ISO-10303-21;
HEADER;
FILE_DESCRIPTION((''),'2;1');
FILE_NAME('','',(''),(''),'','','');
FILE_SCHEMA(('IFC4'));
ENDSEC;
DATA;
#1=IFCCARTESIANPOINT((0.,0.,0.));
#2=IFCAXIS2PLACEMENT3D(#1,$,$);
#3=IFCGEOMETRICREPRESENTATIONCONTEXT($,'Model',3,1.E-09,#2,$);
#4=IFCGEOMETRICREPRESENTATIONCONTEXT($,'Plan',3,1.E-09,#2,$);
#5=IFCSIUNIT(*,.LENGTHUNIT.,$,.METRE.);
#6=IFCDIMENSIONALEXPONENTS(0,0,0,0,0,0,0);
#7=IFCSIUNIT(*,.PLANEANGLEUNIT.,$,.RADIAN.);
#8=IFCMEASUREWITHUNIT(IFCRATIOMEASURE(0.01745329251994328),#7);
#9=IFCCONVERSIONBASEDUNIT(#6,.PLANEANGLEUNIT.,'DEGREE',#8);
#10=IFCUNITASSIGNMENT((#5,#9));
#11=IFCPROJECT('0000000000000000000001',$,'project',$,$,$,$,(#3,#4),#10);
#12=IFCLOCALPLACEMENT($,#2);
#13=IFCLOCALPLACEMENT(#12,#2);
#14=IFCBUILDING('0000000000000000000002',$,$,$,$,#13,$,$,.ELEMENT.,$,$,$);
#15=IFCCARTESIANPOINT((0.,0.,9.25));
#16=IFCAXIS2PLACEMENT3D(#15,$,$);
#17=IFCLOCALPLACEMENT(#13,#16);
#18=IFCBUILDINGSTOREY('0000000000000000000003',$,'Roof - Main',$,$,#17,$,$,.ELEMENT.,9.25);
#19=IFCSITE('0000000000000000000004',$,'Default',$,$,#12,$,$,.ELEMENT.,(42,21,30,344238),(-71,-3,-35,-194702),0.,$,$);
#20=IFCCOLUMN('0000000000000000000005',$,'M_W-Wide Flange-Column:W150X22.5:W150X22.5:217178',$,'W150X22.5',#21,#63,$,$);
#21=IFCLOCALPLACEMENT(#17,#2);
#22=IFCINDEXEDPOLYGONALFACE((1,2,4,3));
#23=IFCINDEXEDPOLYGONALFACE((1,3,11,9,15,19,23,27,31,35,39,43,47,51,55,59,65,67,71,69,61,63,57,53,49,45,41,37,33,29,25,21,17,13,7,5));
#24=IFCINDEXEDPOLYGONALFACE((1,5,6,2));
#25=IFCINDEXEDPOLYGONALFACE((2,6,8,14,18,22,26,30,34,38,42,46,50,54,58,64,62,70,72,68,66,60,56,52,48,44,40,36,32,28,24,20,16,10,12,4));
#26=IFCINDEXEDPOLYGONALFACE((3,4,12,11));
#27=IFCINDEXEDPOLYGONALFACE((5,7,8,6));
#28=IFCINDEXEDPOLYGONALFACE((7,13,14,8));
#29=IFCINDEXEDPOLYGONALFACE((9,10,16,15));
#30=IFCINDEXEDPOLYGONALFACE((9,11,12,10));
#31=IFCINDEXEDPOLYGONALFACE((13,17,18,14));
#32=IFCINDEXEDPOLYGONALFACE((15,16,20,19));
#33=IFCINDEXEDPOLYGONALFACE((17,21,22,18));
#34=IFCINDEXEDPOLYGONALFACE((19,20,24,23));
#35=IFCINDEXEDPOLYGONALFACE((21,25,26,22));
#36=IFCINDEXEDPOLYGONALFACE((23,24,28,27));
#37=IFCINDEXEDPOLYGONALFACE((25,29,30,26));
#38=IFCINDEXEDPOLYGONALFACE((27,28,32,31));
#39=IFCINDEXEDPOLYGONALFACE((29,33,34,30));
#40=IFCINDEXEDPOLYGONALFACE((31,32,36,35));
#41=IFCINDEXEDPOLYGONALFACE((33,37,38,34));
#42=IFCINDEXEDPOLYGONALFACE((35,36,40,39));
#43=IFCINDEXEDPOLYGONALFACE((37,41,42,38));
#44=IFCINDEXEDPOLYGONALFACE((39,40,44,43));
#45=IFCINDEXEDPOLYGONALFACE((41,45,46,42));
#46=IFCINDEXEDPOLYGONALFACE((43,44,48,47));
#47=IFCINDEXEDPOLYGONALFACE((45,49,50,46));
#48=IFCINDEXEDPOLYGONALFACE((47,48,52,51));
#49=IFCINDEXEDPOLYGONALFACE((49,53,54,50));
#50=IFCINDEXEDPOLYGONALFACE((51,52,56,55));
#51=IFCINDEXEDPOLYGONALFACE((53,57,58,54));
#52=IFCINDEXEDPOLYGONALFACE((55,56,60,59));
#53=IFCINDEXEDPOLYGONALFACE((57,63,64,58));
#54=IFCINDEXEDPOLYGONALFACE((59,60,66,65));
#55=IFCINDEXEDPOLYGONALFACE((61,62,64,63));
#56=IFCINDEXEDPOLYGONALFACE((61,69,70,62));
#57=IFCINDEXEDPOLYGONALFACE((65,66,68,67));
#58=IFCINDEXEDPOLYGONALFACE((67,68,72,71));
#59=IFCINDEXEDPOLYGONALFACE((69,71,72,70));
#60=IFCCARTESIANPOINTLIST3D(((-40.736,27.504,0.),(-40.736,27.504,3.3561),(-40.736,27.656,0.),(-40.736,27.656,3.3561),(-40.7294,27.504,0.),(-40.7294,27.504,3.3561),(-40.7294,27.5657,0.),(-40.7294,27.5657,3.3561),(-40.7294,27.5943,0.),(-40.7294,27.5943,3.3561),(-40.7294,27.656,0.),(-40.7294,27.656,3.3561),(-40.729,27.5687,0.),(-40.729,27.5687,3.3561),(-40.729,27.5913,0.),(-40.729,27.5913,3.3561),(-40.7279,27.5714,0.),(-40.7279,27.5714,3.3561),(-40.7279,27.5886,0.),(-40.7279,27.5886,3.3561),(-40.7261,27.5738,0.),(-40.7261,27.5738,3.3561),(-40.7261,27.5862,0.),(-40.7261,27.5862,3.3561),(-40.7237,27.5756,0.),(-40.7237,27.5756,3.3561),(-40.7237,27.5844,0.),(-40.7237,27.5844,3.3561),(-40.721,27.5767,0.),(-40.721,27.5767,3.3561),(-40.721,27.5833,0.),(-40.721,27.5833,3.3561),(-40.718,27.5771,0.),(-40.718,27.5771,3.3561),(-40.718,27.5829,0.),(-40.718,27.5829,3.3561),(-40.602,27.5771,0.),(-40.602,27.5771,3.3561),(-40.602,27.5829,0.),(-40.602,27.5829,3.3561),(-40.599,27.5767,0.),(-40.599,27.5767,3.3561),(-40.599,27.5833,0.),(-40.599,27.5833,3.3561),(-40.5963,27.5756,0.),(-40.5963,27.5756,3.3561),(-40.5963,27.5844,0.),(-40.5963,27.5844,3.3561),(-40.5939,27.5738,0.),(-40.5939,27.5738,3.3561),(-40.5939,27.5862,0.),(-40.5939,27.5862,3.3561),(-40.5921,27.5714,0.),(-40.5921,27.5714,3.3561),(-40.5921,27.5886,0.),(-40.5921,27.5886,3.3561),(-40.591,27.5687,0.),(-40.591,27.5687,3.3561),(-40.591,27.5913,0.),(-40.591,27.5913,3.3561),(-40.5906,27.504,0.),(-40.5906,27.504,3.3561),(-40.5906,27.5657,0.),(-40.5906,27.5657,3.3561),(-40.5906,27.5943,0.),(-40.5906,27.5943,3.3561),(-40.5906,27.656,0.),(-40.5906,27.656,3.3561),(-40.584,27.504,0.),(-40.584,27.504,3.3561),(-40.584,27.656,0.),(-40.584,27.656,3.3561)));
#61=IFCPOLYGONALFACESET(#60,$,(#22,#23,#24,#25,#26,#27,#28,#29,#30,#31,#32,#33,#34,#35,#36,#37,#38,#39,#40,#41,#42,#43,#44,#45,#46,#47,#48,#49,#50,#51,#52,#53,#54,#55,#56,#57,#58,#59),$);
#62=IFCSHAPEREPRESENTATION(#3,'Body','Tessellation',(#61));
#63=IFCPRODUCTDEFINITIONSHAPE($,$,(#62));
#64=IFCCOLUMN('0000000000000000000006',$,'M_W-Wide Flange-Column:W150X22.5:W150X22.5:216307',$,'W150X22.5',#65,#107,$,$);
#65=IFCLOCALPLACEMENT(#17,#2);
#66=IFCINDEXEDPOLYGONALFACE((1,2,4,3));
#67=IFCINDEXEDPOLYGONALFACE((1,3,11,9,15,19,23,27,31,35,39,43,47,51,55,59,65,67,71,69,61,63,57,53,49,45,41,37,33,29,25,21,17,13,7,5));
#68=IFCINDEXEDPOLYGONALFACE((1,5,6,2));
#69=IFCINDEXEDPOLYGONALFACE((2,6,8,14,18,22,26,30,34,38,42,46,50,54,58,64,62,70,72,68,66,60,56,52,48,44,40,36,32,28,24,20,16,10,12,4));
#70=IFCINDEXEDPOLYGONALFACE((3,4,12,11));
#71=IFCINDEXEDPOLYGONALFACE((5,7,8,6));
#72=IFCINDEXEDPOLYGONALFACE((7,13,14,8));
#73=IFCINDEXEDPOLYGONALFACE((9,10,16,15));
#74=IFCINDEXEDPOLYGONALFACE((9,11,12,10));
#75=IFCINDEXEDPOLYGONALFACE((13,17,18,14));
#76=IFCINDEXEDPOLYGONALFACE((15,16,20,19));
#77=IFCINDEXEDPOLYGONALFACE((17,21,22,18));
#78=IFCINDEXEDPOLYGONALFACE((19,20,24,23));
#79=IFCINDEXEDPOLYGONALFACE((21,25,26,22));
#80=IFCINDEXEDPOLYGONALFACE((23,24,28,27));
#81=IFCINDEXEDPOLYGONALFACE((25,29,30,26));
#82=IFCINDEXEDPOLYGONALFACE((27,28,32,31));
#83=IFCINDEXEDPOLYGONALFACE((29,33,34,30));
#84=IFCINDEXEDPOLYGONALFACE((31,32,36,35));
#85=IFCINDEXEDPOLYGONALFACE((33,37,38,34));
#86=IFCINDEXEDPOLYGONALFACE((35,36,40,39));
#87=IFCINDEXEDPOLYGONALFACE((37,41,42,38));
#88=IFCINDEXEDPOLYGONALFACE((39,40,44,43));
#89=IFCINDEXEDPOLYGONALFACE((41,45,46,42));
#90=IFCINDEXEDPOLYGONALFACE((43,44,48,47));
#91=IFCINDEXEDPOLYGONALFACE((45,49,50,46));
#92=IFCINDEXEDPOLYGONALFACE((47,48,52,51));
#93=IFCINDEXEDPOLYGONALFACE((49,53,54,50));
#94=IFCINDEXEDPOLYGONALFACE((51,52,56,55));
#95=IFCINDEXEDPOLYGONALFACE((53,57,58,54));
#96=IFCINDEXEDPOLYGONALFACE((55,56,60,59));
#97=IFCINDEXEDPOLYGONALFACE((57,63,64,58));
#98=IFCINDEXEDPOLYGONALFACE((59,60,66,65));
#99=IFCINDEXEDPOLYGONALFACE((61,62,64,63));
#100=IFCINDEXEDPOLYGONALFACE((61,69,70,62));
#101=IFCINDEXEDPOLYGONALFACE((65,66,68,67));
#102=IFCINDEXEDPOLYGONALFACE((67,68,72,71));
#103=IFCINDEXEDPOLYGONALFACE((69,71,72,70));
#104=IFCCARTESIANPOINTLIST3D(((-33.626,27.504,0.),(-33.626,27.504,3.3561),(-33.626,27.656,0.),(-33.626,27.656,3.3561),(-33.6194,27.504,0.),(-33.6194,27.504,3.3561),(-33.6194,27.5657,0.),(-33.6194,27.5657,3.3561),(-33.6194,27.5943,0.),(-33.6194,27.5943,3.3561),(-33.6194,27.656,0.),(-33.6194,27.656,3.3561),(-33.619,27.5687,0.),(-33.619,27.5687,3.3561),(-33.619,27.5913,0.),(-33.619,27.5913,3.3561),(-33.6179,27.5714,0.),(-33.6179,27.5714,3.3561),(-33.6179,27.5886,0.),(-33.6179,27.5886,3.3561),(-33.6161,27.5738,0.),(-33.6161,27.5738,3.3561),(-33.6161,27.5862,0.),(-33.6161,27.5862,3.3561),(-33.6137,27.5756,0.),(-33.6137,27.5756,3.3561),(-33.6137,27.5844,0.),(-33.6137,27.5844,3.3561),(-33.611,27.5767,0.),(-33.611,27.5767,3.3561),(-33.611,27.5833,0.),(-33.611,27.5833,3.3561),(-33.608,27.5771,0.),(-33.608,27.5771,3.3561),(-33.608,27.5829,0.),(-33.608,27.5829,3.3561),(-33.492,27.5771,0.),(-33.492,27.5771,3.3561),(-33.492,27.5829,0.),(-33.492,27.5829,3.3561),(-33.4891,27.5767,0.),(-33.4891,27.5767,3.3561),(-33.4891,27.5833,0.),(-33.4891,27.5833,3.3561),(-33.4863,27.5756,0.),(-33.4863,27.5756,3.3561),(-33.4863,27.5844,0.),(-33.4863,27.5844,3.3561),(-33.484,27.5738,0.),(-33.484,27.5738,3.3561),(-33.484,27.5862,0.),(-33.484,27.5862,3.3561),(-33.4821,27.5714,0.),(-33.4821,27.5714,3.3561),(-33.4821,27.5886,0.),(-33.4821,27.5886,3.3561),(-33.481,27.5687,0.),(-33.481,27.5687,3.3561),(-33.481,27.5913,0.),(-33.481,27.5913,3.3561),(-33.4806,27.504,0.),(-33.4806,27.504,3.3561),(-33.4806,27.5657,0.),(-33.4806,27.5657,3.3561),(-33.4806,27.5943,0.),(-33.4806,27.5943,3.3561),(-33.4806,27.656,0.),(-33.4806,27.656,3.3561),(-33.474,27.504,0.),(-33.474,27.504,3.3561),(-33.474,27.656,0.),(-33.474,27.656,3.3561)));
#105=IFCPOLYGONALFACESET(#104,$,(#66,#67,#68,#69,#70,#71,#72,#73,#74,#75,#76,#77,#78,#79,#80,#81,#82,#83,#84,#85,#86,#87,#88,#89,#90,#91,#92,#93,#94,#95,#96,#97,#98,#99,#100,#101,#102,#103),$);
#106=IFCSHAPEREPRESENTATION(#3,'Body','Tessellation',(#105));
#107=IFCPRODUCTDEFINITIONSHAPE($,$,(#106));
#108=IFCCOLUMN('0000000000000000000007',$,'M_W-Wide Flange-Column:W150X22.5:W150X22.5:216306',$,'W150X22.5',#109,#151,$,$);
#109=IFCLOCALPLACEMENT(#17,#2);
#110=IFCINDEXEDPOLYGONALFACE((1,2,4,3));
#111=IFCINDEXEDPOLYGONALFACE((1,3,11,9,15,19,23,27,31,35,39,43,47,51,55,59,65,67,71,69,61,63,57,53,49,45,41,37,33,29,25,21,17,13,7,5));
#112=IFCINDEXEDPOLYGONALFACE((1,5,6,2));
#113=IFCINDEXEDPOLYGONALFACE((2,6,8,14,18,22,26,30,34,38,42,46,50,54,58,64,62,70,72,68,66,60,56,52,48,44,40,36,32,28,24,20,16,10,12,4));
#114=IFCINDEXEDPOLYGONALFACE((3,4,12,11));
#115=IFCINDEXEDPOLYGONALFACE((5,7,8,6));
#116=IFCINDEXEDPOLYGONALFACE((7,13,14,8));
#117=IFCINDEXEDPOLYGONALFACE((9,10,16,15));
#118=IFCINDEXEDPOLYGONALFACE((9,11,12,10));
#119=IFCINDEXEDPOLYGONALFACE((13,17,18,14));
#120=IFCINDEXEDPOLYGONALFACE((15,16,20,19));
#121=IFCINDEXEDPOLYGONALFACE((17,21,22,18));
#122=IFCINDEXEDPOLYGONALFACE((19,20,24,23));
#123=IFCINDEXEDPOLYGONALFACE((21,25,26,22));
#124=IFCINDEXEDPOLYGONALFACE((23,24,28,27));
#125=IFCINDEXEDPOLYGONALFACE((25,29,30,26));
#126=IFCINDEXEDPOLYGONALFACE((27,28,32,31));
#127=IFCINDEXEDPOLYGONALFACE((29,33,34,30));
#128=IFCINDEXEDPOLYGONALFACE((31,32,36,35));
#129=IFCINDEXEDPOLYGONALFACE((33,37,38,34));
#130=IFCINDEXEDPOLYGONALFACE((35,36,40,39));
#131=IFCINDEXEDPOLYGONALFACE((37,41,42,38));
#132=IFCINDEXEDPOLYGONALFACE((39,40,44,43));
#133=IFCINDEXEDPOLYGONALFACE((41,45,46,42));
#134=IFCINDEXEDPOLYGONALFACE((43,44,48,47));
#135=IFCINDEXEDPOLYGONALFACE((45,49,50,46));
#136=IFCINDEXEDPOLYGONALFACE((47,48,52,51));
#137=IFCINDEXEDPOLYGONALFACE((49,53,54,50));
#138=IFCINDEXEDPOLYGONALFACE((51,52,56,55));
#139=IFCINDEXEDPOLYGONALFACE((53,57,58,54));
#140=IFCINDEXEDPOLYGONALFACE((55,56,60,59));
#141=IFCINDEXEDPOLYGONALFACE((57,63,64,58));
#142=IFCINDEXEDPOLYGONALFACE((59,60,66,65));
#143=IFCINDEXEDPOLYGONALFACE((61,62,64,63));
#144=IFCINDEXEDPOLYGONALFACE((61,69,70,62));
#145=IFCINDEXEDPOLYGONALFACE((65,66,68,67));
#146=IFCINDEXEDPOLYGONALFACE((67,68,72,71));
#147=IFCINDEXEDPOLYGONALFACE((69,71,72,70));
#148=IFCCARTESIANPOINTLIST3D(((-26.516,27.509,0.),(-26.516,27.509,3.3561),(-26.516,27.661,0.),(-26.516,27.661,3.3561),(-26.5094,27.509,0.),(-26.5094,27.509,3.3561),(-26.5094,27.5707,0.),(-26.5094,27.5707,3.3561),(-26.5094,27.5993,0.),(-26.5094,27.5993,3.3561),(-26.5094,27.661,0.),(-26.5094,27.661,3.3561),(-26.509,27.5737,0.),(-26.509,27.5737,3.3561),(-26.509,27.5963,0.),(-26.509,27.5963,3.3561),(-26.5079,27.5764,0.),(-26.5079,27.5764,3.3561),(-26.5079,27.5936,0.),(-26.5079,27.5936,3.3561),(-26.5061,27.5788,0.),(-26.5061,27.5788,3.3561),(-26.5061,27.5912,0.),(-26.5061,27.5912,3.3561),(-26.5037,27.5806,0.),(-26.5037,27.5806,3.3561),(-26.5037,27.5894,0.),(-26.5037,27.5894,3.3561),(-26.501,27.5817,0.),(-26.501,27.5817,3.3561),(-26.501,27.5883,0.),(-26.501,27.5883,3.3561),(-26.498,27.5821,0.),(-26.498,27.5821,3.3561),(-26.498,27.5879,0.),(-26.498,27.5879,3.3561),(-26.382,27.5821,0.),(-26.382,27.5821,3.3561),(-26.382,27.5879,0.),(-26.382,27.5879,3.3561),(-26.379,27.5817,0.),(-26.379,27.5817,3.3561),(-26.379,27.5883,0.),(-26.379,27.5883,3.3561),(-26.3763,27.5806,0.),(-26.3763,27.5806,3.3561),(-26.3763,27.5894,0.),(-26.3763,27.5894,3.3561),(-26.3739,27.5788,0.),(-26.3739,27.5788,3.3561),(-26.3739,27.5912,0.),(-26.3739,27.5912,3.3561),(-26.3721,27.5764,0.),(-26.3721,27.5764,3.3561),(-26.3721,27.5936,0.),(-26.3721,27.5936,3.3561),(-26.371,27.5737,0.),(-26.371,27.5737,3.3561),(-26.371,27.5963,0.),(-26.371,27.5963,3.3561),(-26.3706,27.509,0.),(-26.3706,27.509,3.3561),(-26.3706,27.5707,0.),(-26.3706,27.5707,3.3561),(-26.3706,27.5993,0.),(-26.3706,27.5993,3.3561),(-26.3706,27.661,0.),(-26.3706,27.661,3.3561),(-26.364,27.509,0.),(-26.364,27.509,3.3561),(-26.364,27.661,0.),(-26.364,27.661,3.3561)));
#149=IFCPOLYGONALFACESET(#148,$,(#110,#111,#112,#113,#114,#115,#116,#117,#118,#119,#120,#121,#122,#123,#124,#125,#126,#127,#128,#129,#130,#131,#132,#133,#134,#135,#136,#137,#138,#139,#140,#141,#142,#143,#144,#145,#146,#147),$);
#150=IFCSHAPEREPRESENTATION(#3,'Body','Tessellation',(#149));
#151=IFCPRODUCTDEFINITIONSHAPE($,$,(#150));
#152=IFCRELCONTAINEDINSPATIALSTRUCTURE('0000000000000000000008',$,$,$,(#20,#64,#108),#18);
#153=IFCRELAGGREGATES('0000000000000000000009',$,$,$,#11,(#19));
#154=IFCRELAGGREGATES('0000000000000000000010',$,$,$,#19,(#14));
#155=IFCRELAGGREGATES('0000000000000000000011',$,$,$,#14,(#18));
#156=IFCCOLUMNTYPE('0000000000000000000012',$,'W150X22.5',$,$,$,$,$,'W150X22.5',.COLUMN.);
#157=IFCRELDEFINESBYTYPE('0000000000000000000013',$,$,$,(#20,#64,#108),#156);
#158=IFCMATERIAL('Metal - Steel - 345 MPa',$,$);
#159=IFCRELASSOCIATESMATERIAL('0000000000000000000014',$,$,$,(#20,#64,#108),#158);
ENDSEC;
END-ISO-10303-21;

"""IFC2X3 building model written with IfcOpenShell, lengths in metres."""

from ifc_helpers import new_model, entity, si_unit, converted_unit, frame, frame_2d, origin, place, context, project, spatial, polyline, circle_curve, parameter, trimmed, segment, composite_curve, outline, extrude, source, transform, mapped, material, type_object, type_shapes, element, save


model = new_model("IFC2X3")

# Units and contexts
model_context = context("Model", 3, precision=1e-09, world=origin())
plan_context = context("Plan", 3, precision=1e-09, world=origin())
ifc_project = project(units=[si_unit("LENGTHUNIT", "METRE"), converted_unit("PLANEANGLEUNIT", "DEGREE", entity("IfcRatioMeasure", 0.01745329251994328), si_unit("PLANEANGLEUNIT", "RADIAN"), dimensions=[0, 0, 0, 0, 0, 0, 0])], contexts=[model_context, plan_context])

# Site, building, storey
site_placement = place(None, origin())
site = spatial("IfcSite", under=ifc_project, at=site_placement, Name="Default", CompositionType="ELEMENT", RefLatitude=(42, 21, 30, 344238), RefLongitude=(-71, -3, -35, -194702), RefElevation=0.0)
building_placement = place(site_placement, origin())
building = spatial("IfcBuilding", under=site, at=building_placement, CompositionType="ELEMENT")
storey_placement = place(building_placement, frame((0.0, 0.0, 9.25)))
storey = spatial("IfcBuildingStorey", under=building, at=storey_placement, Name="Roof - Main", CompositionType="ELEMENT", Elevation=9.25)

# Columns
ifc_material_1 = material(Name="Metal - Steel - 345 MPa")
column_type_1 = type_object("IfcColumnType", Name="W150X22.5", ElementType="W150X22.5", PredefinedType="COLUMN")
shared_shape_1 = source(origin(), model_context, "Body", "SweptSolid", [
    extrude(outline(composite_curve([segment(polyline([(-0.076, -0.076), (-0.0694, -0.076)]), True, "CONTINUOUS"), segment(polyline([(-0.0694, -0.076), (-0.0694, -0.0143)]), True, "CONTINUOUS"), segment(trimmed(circle_curve(frame_2d((-0.058, -0.0143), x_axis=(0.0, -1.0)), 0.0114), [parameter(180.0)], [parameter(270.0)], True, "PARAMETER"), False, "CONTINUOUS"), segment(polyline([(-0.058, -0.0029), (0.058, -0.0029)]), True, "CONTINUOUS"), segment(trimmed(circle_curve(frame_2d((0.058, -0.0143), x_axis=(0.0, -1.0)), 0.0114), [parameter(90.0)], [parameter(180.0)], True, "PARAMETER"), False, "CONTINUOUS"), segment(polyline([(0.0694, -0.0143), (0.0694, -0.076)]), True, "CONTINUOUS"), segment(polyline([(0.0694, -0.076), (0.076, -0.076)]), True, "CONTINUOUS"), segment(polyline([(0.076, -0.076), (0.076, 0.076)]), True, "CONTINUOUS"), segment(polyline([(0.076, 0.076), (0.0694, 0.076)]), True, "CONTINUOUS"), segment(polyline([(0.0694, 0.076), (0.0694, 0.0143)]), True, "CONTINUOUS"), segment(trimmed(circle_curve(frame_2d((0.058, 0.0143), x_axis=(0.0, -1.0)), 0.0114), [parameter(360.0)], [parameter(90.0)], True, "PARAMETER"), False, "CONTINUOUS"), segment(polyline([(0.058, 0.0029), (-0.058, 0.0029)]), True, "CONTINUOUS"), segment(trimmed(circle_curve(frame_2d((-0.058, 0.0143), x_axis=(0.0, -1.0)), 0.0114), [parameter(270.0)], [parameter(360.0)], True, "PARAMETER"), False, "CONTINUOUS"), segment(polyline([(-0.0694, 0.0143), (-0.0694, 0.076)]), True, "CONTINUOUS"), segment(polyline([(-0.0694, 0.076), (-0.076, 0.076)]), True, "CONTINUOUS"), segment(polyline([(-0.076, 0.076), (-0.076, -0.076)]), True, "CONTINUOUS")], self_intersect=False)), frame((0.0, 0.0, 9.25), z_axis=(0.0, 0.0, 1.0), x_axis=(0.0, 1.0, 0.0)), (0.0, 0.0, 1.0), 3.3561),
])
type_shapes(column_type_1, [shared_shape_1])
for number, where, z_axis, x_axis, name in (
    (1, (-40.66, 27.58, -9.25), (0.0, 0.0, 1.0), (0.0, -1.0, 0.0), "M_W-Wide Flange-Column:W150X22.5:W150X22.5:217178"),
    (2, (-33.55, 27.58, -9.25), (0.0, 0.0, 1.0), (0.0, -1.0, 0.0), "M_W-Wide Flange-Column:W150X22.5:W150X22.5:216307"),
    (3, (-26.44, 27.585, -9.25), (0.0, 0.0, 1.0), (0.0, -1.0, 0.0), "M_W-Wide Flange-Column:W150X22.5:W150X22.5:216306"),
):
    element("IfcColumn", number, at=place(storey_placement, frame(where, z_axis=z_axis, x_axis=x_axis)), inside=storey, type_object=column_type_1, material=ifc_material_1, Name=name, ObjectType="W150X22.5", context=model_context, shape_type="MappedRepresentation", body=[
        mapped(shared_shape_1, transform((0.0, 0.0, 0.0), scale=1.0)),
    ])

save(model, "model.ifc")
